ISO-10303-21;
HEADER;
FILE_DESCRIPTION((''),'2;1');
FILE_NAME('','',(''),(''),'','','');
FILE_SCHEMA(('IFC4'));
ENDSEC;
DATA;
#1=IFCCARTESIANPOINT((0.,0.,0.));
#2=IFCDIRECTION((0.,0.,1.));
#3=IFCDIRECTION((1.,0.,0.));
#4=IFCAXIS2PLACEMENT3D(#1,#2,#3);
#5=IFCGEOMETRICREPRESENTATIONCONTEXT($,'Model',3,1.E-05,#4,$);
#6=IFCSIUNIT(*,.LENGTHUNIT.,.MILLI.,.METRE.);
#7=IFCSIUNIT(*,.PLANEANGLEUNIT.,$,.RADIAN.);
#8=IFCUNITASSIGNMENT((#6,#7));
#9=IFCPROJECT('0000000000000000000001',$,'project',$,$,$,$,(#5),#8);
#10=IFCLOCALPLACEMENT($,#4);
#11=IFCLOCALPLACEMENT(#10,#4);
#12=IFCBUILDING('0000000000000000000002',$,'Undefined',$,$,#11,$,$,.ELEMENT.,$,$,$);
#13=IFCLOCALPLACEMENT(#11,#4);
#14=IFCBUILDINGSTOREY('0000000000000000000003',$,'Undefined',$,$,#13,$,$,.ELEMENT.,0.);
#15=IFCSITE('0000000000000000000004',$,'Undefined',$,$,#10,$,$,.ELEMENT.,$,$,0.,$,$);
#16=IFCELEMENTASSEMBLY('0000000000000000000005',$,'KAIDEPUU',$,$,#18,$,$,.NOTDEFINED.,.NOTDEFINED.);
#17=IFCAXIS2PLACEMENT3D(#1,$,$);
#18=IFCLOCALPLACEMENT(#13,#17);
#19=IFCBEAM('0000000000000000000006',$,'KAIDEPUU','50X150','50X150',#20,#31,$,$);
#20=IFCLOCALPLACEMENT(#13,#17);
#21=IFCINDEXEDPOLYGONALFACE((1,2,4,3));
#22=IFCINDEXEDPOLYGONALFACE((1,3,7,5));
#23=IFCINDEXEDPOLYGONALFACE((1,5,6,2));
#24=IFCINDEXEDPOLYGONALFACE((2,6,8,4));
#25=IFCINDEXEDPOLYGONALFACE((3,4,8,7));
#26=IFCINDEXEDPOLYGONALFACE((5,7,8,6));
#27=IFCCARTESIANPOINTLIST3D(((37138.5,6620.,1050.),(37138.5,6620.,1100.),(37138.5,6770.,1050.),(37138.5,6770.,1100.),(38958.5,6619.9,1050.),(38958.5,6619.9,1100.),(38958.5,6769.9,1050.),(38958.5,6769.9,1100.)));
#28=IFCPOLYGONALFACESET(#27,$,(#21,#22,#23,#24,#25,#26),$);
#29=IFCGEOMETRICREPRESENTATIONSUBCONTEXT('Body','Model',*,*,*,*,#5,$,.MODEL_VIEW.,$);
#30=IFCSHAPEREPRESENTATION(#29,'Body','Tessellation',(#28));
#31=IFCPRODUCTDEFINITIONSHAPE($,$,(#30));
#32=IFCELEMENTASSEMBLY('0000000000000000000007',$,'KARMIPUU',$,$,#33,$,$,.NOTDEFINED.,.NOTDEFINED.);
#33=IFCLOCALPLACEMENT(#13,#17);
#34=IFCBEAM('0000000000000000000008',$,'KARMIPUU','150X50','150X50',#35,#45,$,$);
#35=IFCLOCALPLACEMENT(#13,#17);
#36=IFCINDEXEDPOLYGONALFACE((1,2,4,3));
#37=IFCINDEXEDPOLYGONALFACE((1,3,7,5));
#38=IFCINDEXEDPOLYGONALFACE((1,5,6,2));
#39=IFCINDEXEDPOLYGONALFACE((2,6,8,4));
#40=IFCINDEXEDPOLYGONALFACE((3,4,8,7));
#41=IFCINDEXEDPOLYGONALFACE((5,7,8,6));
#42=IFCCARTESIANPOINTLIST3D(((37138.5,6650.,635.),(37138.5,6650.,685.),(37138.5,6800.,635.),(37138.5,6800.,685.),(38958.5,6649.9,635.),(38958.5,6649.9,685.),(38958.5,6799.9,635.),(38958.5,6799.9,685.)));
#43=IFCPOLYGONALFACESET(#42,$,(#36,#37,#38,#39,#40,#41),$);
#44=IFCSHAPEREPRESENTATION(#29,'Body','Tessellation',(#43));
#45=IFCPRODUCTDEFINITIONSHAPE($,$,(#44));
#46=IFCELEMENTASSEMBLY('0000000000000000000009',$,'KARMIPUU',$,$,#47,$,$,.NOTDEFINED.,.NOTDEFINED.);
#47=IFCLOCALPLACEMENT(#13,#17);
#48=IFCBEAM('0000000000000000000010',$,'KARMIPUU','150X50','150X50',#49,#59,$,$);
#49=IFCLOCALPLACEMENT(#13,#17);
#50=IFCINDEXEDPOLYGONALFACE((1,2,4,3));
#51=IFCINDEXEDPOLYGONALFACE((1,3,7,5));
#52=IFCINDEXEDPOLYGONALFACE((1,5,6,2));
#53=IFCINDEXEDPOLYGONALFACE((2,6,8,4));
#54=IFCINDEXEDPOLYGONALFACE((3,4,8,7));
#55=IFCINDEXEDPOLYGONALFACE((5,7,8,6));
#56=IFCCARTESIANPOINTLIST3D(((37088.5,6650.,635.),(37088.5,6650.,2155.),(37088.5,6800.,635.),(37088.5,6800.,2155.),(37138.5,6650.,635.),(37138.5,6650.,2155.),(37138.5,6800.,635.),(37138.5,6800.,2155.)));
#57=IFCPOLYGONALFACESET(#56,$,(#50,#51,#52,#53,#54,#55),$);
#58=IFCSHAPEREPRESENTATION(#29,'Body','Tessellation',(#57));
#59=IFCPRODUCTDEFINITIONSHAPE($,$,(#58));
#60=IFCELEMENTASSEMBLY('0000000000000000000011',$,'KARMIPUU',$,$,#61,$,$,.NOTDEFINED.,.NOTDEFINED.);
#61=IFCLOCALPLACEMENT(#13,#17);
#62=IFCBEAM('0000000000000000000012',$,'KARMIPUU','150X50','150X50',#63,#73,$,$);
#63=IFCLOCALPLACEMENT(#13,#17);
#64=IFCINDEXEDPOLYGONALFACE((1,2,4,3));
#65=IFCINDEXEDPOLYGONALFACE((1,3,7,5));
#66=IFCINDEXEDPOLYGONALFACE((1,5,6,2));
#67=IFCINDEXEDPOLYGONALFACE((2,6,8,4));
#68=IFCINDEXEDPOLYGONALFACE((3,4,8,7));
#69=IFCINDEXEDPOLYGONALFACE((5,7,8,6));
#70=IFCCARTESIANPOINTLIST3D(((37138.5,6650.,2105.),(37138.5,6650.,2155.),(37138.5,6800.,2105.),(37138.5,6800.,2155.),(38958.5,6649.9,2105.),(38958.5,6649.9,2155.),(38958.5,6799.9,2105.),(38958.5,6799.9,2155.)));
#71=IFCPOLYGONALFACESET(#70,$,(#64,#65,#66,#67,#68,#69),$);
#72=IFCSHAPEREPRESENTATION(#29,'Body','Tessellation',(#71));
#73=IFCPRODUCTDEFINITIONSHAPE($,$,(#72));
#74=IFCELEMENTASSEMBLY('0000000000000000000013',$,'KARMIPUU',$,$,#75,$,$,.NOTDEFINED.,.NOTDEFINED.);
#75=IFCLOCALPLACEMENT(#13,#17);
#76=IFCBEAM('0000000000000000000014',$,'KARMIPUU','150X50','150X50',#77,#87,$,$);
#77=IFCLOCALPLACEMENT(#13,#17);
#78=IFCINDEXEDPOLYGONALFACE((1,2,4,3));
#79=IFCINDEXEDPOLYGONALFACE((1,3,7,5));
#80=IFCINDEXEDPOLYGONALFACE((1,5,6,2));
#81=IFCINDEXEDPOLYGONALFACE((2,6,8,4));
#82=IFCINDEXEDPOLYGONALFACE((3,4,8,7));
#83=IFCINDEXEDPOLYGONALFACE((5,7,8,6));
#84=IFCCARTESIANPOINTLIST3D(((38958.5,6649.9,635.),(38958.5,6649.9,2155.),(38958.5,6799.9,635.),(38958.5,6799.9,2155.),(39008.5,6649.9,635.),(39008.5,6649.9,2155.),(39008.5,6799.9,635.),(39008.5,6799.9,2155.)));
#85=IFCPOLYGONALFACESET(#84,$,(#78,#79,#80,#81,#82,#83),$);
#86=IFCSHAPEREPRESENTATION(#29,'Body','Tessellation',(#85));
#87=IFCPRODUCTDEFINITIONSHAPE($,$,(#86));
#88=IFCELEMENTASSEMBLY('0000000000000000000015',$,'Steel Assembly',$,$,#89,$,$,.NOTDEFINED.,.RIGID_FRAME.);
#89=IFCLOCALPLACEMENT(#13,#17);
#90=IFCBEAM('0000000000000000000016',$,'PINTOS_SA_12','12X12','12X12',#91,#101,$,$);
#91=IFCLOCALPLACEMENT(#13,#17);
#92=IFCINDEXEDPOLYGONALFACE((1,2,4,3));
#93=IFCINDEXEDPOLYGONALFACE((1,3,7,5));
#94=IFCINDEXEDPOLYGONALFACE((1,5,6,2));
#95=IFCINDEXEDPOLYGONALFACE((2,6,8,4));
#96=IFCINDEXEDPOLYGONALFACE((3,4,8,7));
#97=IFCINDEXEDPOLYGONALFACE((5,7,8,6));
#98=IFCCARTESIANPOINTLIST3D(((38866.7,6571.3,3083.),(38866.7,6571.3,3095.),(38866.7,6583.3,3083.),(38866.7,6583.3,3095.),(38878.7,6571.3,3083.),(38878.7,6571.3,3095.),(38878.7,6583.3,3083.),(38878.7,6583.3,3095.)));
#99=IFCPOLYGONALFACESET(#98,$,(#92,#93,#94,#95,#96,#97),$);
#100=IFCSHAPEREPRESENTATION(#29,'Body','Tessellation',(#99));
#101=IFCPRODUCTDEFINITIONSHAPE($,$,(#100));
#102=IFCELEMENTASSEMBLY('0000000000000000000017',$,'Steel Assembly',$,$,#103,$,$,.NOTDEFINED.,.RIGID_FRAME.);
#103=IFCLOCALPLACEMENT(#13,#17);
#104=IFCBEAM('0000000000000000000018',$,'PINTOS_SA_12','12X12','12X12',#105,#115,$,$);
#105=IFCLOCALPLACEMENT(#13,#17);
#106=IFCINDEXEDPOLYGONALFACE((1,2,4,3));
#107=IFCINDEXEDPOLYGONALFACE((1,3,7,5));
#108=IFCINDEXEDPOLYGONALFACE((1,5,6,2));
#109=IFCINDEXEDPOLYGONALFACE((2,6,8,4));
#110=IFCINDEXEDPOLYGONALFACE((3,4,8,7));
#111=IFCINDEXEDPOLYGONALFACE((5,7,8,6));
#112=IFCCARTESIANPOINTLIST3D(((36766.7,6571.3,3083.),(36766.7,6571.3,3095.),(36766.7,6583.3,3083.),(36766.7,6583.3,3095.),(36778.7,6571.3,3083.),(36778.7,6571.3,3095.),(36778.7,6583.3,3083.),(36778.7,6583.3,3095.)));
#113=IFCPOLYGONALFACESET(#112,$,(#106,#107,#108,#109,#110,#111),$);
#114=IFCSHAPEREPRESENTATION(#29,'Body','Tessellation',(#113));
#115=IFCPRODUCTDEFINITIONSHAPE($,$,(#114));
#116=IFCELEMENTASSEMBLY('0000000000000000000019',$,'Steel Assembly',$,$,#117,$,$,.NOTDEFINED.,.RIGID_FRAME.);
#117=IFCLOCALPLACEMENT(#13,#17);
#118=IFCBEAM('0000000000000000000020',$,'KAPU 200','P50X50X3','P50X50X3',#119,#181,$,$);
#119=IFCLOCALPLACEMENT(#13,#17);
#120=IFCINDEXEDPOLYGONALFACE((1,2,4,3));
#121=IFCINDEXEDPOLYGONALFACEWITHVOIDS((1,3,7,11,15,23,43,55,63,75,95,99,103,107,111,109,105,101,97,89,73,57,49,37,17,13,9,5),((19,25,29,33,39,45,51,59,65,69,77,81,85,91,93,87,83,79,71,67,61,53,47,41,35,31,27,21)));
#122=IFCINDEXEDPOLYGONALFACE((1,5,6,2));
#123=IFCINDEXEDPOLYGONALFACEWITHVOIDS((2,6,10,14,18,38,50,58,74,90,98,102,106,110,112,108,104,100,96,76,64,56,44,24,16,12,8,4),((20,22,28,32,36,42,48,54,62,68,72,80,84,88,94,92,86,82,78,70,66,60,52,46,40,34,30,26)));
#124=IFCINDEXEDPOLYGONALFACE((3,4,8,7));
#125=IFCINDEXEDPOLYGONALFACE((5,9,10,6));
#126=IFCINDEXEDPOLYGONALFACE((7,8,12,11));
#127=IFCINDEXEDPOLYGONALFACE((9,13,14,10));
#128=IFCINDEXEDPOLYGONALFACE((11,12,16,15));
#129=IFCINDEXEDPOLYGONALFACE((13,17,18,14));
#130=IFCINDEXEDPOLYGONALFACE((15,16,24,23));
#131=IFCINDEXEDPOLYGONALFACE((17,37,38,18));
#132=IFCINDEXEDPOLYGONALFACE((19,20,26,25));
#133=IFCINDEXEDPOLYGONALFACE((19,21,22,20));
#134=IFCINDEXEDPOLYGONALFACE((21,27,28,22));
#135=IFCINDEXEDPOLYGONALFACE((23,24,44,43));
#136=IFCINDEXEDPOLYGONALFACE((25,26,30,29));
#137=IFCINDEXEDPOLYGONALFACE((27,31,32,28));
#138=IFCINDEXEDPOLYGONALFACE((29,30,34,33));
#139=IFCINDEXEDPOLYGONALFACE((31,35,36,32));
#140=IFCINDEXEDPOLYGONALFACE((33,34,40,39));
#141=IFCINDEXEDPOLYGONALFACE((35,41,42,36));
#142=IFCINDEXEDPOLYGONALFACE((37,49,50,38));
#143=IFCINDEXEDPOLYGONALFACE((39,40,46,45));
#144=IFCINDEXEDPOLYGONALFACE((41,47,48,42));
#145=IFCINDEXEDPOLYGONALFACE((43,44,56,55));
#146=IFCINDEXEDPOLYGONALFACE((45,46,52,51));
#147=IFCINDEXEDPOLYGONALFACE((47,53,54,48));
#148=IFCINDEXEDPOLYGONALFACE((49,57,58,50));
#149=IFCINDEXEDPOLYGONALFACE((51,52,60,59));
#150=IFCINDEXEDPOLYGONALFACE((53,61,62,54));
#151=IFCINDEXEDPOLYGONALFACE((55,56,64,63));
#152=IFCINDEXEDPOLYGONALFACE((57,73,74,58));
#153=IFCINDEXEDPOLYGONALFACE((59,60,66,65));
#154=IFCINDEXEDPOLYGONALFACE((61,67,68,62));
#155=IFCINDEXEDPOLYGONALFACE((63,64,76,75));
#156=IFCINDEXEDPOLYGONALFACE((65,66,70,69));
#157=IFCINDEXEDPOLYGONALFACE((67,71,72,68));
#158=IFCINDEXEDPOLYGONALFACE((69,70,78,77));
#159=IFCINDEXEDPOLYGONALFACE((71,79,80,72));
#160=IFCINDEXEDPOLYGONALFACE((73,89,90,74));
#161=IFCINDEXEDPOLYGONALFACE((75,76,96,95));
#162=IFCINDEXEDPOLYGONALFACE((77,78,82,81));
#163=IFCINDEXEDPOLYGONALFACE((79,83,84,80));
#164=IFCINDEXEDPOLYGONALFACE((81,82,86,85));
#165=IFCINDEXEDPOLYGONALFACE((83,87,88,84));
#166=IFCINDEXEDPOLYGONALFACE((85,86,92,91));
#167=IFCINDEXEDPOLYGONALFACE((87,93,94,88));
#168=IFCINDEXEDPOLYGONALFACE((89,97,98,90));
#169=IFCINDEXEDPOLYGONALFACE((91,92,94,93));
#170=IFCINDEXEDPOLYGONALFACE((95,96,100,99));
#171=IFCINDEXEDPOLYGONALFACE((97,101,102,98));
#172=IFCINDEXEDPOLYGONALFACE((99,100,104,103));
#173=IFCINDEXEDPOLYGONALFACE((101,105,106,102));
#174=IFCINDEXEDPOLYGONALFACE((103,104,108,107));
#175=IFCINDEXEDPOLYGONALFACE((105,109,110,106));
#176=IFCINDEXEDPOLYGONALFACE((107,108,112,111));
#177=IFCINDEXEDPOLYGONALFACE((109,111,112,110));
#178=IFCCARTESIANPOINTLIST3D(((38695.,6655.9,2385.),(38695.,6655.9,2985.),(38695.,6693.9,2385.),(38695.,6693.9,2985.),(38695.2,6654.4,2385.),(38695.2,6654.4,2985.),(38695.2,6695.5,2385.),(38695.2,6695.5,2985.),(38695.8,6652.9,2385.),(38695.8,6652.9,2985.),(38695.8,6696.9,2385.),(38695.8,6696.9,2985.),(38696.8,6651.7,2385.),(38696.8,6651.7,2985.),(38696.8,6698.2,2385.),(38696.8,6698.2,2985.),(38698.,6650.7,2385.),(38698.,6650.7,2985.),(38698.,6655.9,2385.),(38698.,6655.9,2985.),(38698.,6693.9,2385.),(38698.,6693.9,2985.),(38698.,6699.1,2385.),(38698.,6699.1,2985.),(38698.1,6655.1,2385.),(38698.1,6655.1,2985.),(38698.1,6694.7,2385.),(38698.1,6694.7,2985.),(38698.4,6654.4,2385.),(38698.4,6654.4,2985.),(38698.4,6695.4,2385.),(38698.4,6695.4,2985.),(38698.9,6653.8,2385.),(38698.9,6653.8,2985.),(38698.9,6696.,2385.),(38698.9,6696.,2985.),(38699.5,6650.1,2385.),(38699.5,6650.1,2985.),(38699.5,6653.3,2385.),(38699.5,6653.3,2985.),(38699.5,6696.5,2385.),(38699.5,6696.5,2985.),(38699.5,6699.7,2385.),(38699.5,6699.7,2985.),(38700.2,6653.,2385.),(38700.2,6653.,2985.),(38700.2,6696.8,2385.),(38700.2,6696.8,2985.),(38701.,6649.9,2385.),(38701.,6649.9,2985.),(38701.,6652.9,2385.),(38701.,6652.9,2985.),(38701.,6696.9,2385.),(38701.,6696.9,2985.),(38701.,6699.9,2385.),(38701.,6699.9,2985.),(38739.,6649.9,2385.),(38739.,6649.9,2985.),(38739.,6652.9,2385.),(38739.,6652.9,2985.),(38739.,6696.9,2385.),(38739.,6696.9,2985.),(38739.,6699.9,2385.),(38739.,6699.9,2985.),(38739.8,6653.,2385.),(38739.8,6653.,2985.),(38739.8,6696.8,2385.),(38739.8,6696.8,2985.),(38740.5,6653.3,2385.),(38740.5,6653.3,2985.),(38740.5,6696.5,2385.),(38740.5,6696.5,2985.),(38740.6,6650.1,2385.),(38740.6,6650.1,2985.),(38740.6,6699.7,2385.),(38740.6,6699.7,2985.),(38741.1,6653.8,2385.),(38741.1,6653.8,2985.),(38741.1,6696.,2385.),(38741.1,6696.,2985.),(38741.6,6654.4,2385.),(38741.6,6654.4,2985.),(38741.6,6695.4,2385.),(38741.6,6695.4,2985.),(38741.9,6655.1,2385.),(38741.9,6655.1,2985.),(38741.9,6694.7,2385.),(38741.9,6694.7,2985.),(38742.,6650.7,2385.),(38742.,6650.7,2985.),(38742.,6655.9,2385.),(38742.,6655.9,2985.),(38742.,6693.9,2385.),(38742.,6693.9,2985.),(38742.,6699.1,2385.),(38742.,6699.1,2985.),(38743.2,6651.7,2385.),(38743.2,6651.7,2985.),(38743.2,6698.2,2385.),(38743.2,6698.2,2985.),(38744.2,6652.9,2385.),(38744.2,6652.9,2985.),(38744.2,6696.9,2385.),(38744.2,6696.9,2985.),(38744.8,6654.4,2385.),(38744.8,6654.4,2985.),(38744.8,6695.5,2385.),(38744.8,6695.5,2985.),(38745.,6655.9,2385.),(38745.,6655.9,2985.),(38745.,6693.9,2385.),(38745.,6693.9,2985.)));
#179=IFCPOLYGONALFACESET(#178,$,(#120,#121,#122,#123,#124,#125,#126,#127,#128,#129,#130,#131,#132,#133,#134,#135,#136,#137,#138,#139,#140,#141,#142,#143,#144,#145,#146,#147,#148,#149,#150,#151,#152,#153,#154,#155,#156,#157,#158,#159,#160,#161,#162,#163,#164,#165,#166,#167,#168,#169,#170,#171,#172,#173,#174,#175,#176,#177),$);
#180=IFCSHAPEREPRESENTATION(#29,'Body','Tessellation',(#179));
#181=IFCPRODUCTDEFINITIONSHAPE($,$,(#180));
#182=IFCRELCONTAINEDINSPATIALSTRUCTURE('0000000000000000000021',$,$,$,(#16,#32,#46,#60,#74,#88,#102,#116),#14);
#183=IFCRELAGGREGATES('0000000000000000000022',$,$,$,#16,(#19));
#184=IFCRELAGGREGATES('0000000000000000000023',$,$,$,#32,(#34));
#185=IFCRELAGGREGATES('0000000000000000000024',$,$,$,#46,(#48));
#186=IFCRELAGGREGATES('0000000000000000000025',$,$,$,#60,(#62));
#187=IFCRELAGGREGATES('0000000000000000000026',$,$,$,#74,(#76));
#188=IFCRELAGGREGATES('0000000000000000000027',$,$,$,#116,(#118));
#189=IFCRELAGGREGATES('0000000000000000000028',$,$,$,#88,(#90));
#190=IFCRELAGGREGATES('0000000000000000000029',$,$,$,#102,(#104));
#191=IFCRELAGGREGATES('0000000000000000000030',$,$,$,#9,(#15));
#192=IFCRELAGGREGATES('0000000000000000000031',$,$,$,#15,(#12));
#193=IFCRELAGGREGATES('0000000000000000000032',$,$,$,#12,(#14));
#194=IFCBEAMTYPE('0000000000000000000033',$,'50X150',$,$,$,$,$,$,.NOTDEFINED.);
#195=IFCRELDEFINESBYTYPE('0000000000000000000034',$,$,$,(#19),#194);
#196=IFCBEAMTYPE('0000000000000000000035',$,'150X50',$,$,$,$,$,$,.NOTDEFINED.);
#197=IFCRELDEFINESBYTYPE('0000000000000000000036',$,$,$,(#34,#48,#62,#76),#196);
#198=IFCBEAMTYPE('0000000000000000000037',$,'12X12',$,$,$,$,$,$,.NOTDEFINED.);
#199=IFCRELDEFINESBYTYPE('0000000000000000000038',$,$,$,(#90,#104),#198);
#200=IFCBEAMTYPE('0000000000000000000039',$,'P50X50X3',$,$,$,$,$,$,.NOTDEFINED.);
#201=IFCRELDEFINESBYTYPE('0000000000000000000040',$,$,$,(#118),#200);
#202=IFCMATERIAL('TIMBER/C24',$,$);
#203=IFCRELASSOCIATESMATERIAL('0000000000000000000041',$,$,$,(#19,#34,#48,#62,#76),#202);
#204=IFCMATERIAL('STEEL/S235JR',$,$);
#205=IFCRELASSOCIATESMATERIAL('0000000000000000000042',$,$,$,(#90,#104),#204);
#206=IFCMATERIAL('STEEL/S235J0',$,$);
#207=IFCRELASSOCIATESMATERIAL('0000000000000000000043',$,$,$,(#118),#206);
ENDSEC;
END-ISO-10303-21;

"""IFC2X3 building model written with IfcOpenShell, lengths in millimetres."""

from ifc_helpers import new_model, si_unit, frame, origin_with_axes, origin_2d_with_axis, place, context, subcontext, project, spatial, rectangle, hollow_rectangle, extrude, material, type_object, element, aggregate, save


model = new_model("IFC2X3")

# Units and contexts
model_context = context("Model", 3, precision=1e-05, world=origin_with_axes())
body_context = subcontext(model_context, "Body", "Model", "MODEL_VIEW")
ifc_project = project(units=[si_unit("LENGTHUNIT", "METRE", prefix="MILLI"), si_unit("PLANEANGLEUNIT", "RADIAN")], contexts=[model_context])

# Site, building, storey
site_placement = place(None, origin_with_axes())
site = spatial("IfcSite", under=ifc_project, at=site_placement, Name="Undefined", CompositionType="ELEMENT", RefElevation=0.0)
building_placement = place(site_placement, origin_with_axes())
building = spatial("IfcBuilding", under=site, at=building_placement, Name="Undefined", CompositionType="ELEMENT")
storey_placement = place(building_placement, origin_with_axes())
storey = spatial("IfcBuildingStorey", under=building, at=storey_placement, Name="Undefined", CompositionType="ELEMENT", Elevation=0.0)

# Element assemblies, beams
assembly_1_placement = place(storey_placement, origin_with_axes())
assembly_1 = element("IfcElementAssembly", 1, at=assembly_1_placement, inside=storey, Name="KAIDEPUU", AssemblyPlace="NOTDEFINED", PredefinedType="NOTDEFINED")
ifc_material_1 = material(Name="TIMBER/C24")
beam_type_1 = type_object("IfcBeamType", Name="50X150", PredefinedType="NOTDEFINED")
beam_1_placement = place(assembly_1_placement, frame((37138.5, 6695.0, 1075.0), z_axis=(0.0, 0.0, 1.0), x_axis=(1.0, -0.00003, 0.0)))
beam_1 = element("IfcBeam", 2, at=beam_1_placement, type_object=beam_type_1, material=ifc_material_1, Name="KAIDEPUU", Description="50X150", ObjectType="50X150", context=body_context, shape_type="SweptSolid", body=[
    extrude(rectangle(XDim=150.0, YDim=50.0, at=origin_2d_with_axis()), frame((1820.0, 0.0, 0.0), z_axis=(-1.0, 0.0, 0.0), x_axis=(0.0, -1.0, 0.0)), (0.0, 0.0, 1.0), 1820.0),
])
aggregate(assembly_1, [beam_1])
assembly_2_placement = place(storey_placement, origin_with_axes())
assembly_2 = element("IfcElementAssembly", 3, at=assembly_2_placement, inside=storey, Name="KARMIPUU", AssemblyPlace="NOTDEFINED", PredefinedType="NOTDEFINED")
beam_type_2 = type_object("IfcBeamType", Name="150X50", PredefinedType="NOTDEFINED")
beam_2_placement = place(assembly_2_placement, frame((37138.5, 6725.0, 660.0), z_axis=(-0.00003, -1.0, 0.0), x_axis=(1.0, -0.00003, 0.0)))
beam_2 = element("IfcBeam", 4, at=beam_2_placement, type_object=beam_type_2, material=ifc_material_1, Name="KARMIPUU", Description="150X50", ObjectType="150X50", context=body_context, shape_type="SweptSolid", body=[
    extrude(rectangle(XDim=50.0, YDim=150.0, at=origin_2d_with_axis()), frame((1820.0, 0.0, 0.0), z_axis=(-1.0, 0.0, 0.0), x_axis=(0.0, -1.0, 0.0)), (0.0, 0.0, 1.0), 1820.0),
])
aggregate(assembly_2, [beam_2])
assembly_3_placement = place(storey_placement, origin_with_axes())
assembly_3 = element("IfcElementAssembly", 5, at=assembly_3_placement, inside=storey, Name="KARMIPUU", AssemblyPlace="NOTDEFINED", PredefinedType="NOTDEFINED")
beam_3_placement = place(assembly_3_placement, frame((37113.5, 6725.0, 2155.0), z_axis=(-0.00003, -1.0, 0.0), x_axis=(0.0, 0.0, -1.0)))
beam_3 = element("IfcBeam", 6, at=beam_3_placement, type_object=beam_type_2, material=ifc_material_1, Name="KARMIPUU", Description="150X50", ObjectType="150X50", context=body_context, shape_type="SweptSolid", body=[
    extrude(rectangle(XDim=50.0, YDim=150.0, at=origin_2d_with_axis()), frame((1520.0, 0.0, 0.0), z_axis=(-1.0, 0.0, 0.0), x_axis=(0.0, -1.0, 0.0)), (0.0, 0.0, 1.0), 1520.0),
])
aggregate(assembly_3, [beam_3])
assembly_4_placement = place(storey_placement, origin_with_axes())
assembly_4 = element("IfcElementAssembly", 7, at=assembly_4_placement, inside=storey, Name="KARMIPUU", AssemblyPlace="NOTDEFINED", PredefinedType="NOTDEFINED")
beam_4_placement = place(assembly_4_placement, frame((38958.5, 6724.9, 2130.0), z_axis=(-0.00003, -1.0, 0.0), x_axis=(-1.0, 0.00003, 0.0)))
beam_4 = element("IfcBeam", 8, at=beam_4_placement, type_object=beam_type_2, material=ifc_material_1, Name="KARMIPUU", Description="150X50", ObjectType="150X50", context=body_context, shape_type="SweptSolid", body=[
    extrude(rectangle(XDim=50.0, YDim=150.0, at=origin_2d_with_axis()), frame((1820.0, 0.0, 0.0), z_axis=(-1.0, 0.0, 0.0), x_axis=(0.0, -1.0, 0.0)), (0.0, 0.0, 1.0), 1820.0),
])
aggregate(assembly_4, [beam_4])
assembly_5_placement = place(storey_placement, origin_with_axes())
assembly_5 = element("IfcElementAssembly", 9, at=assembly_5_placement, inside=storey, Name="KARMIPUU", AssemblyPlace="NOTDEFINED", PredefinedType="NOTDEFINED")
beam_5_placement = place(assembly_5_placement, frame((38983.5, 6724.9, 635.0), z_axis=(-0.00003, -1.0, 0.0), x_axis=(0.0, 0.0, 1.0)))
beam_5 = element("IfcBeam", 10, at=beam_5_placement, type_object=beam_type_2, material=ifc_material_1, Name="KARMIPUU", Description="150X50", ObjectType="150X50", context=body_context, shape_type="SweptSolid", body=[
    extrude(rectangle(XDim=50.0, YDim=150.0, at=origin_2d_with_axis()), frame((1520.0, 0.0, 0.0), z_axis=(-1.0, 0.0, 0.0), x_axis=(0.0, -1.0, 0.0)), (0.0, 0.0, 1.0), 1520.0),
])
aggregate(assembly_5, [beam_5])
assembly_6_placement = place(storey_placement, origin_with_axes())
assembly_6 = element("IfcElementAssembly", 11, at=assembly_6_placement, inside=storey, Name="Steel Assembly", AssemblyPlace="NOTDEFINED", PredefinedType="RIGID_FRAME")
ifc_material_2 = material(Name="STEEL/S235JR")
beam_type_3 = type_object("IfcBeamType", Name="12X12", PredefinedType="NOTDEFINED")
beam_6_placement = place(assembly_6_placement, frame((38878.7, 6577.3, 3089.0), z_axis=(0.0, 0.0, 1.0), x_axis=(-1.0, 0.00003, 0.0)))
beam_6 = element("IfcBeam", 12, at=beam_6_placement, type_object=beam_type_3, material=ifc_material_2, Name="PINTOS_SA_12", Description="12X12", ObjectType="12X12", context=body_context, shape_type="SweptSolid", body=[
    extrude(rectangle(XDim=12.0, YDim=12.0, at=origin_2d_with_axis()), frame((12.0, 0.0, 0.0), z_axis=(-1.0, 0.0, 0.0), x_axis=(0.0, -1.0, 0.0)), (0.0, 0.0, 1.0), 12.0),
])
assembly_7_placement = place(storey_placement, origin_with_axes())
assembly_7 = element("IfcElementAssembly", 13, at=assembly_7_placement, inside=storey, Name="Steel Assembly", AssemblyPlace="NOTDEFINED", PredefinedType="RIGID_FRAME")
beam_7_placement = place(assembly_7_placement, frame((36766.7, 6577.3, 3089.0), z_axis=(0.0, 0.0, 1.0), x_axis=(1.0, -0.00003, 0.0)))
beam_7 = element("IfcBeam", 14, at=beam_7_placement, type_object=beam_type_3, material=ifc_material_2, Name="PINTOS_SA_12", Description="12X12", ObjectType="12X12", context=body_context, shape_type="SweptSolid", body=[
    extrude(rectangle(XDim=12.0, YDim=12.0, at=origin_2d_with_axis()), frame((12.0, 0.0, 0.0), z_axis=(-1.0, 0.0, 0.0), x_axis=(0.0, -1.0, 0.0)), (0.0, 0.0, 1.0), 12.0),
])
assembly_8_placement = place(storey_placement, origin_with_axes())
assembly_8 = element("IfcElementAssembly", 15, at=assembly_8_placement, inside=storey, Name="Steel Assembly", AssemblyPlace="NOTDEFINED", PredefinedType="RIGID_FRAME")
ifc_material_3 = material(Name="STEEL/S235J0")
beam_type_4 = type_object("IfcBeamType", Name="P50X50X3", PredefinedType="NOTDEFINED")
beam_8_placement = place(assembly_8_placement, frame((38720.0, 6674.9, 2985.0), z_axis=(1.0, -0.00003, 0.0), x_axis=(0.0, 0.0, -1.0)))
beam_8 = element("IfcBeam", 16, at=beam_8_placement, type_object=beam_type_4, material=ifc_material_3, Name="KAPU 200", Description="P50X50X3", ObjectType="P50X50X3", context=body_context, shape_type="SweptSolid", body=[
    extrude(hollow_rectangle(XDim=50.0, YDim=50.0, WallThickness=3.0, InnerFilletRadius=3.0, OuterFilletRadius=6.0, at=origin_2d_with_axis()), frame((600.0, 0.0, 0.0), z_axis=(-1.0, 0.0, 0.0), x_axis=(0.0, -1.0, 0.0)), (0.0, 0.0, 1.0), 600.0),
])
aggregate(assembly_8, [beam_8])

aggregate(assembly_6, [beam_6])
aggregate(assembly_7, [beam_7])

save(model, "model.ifc")
